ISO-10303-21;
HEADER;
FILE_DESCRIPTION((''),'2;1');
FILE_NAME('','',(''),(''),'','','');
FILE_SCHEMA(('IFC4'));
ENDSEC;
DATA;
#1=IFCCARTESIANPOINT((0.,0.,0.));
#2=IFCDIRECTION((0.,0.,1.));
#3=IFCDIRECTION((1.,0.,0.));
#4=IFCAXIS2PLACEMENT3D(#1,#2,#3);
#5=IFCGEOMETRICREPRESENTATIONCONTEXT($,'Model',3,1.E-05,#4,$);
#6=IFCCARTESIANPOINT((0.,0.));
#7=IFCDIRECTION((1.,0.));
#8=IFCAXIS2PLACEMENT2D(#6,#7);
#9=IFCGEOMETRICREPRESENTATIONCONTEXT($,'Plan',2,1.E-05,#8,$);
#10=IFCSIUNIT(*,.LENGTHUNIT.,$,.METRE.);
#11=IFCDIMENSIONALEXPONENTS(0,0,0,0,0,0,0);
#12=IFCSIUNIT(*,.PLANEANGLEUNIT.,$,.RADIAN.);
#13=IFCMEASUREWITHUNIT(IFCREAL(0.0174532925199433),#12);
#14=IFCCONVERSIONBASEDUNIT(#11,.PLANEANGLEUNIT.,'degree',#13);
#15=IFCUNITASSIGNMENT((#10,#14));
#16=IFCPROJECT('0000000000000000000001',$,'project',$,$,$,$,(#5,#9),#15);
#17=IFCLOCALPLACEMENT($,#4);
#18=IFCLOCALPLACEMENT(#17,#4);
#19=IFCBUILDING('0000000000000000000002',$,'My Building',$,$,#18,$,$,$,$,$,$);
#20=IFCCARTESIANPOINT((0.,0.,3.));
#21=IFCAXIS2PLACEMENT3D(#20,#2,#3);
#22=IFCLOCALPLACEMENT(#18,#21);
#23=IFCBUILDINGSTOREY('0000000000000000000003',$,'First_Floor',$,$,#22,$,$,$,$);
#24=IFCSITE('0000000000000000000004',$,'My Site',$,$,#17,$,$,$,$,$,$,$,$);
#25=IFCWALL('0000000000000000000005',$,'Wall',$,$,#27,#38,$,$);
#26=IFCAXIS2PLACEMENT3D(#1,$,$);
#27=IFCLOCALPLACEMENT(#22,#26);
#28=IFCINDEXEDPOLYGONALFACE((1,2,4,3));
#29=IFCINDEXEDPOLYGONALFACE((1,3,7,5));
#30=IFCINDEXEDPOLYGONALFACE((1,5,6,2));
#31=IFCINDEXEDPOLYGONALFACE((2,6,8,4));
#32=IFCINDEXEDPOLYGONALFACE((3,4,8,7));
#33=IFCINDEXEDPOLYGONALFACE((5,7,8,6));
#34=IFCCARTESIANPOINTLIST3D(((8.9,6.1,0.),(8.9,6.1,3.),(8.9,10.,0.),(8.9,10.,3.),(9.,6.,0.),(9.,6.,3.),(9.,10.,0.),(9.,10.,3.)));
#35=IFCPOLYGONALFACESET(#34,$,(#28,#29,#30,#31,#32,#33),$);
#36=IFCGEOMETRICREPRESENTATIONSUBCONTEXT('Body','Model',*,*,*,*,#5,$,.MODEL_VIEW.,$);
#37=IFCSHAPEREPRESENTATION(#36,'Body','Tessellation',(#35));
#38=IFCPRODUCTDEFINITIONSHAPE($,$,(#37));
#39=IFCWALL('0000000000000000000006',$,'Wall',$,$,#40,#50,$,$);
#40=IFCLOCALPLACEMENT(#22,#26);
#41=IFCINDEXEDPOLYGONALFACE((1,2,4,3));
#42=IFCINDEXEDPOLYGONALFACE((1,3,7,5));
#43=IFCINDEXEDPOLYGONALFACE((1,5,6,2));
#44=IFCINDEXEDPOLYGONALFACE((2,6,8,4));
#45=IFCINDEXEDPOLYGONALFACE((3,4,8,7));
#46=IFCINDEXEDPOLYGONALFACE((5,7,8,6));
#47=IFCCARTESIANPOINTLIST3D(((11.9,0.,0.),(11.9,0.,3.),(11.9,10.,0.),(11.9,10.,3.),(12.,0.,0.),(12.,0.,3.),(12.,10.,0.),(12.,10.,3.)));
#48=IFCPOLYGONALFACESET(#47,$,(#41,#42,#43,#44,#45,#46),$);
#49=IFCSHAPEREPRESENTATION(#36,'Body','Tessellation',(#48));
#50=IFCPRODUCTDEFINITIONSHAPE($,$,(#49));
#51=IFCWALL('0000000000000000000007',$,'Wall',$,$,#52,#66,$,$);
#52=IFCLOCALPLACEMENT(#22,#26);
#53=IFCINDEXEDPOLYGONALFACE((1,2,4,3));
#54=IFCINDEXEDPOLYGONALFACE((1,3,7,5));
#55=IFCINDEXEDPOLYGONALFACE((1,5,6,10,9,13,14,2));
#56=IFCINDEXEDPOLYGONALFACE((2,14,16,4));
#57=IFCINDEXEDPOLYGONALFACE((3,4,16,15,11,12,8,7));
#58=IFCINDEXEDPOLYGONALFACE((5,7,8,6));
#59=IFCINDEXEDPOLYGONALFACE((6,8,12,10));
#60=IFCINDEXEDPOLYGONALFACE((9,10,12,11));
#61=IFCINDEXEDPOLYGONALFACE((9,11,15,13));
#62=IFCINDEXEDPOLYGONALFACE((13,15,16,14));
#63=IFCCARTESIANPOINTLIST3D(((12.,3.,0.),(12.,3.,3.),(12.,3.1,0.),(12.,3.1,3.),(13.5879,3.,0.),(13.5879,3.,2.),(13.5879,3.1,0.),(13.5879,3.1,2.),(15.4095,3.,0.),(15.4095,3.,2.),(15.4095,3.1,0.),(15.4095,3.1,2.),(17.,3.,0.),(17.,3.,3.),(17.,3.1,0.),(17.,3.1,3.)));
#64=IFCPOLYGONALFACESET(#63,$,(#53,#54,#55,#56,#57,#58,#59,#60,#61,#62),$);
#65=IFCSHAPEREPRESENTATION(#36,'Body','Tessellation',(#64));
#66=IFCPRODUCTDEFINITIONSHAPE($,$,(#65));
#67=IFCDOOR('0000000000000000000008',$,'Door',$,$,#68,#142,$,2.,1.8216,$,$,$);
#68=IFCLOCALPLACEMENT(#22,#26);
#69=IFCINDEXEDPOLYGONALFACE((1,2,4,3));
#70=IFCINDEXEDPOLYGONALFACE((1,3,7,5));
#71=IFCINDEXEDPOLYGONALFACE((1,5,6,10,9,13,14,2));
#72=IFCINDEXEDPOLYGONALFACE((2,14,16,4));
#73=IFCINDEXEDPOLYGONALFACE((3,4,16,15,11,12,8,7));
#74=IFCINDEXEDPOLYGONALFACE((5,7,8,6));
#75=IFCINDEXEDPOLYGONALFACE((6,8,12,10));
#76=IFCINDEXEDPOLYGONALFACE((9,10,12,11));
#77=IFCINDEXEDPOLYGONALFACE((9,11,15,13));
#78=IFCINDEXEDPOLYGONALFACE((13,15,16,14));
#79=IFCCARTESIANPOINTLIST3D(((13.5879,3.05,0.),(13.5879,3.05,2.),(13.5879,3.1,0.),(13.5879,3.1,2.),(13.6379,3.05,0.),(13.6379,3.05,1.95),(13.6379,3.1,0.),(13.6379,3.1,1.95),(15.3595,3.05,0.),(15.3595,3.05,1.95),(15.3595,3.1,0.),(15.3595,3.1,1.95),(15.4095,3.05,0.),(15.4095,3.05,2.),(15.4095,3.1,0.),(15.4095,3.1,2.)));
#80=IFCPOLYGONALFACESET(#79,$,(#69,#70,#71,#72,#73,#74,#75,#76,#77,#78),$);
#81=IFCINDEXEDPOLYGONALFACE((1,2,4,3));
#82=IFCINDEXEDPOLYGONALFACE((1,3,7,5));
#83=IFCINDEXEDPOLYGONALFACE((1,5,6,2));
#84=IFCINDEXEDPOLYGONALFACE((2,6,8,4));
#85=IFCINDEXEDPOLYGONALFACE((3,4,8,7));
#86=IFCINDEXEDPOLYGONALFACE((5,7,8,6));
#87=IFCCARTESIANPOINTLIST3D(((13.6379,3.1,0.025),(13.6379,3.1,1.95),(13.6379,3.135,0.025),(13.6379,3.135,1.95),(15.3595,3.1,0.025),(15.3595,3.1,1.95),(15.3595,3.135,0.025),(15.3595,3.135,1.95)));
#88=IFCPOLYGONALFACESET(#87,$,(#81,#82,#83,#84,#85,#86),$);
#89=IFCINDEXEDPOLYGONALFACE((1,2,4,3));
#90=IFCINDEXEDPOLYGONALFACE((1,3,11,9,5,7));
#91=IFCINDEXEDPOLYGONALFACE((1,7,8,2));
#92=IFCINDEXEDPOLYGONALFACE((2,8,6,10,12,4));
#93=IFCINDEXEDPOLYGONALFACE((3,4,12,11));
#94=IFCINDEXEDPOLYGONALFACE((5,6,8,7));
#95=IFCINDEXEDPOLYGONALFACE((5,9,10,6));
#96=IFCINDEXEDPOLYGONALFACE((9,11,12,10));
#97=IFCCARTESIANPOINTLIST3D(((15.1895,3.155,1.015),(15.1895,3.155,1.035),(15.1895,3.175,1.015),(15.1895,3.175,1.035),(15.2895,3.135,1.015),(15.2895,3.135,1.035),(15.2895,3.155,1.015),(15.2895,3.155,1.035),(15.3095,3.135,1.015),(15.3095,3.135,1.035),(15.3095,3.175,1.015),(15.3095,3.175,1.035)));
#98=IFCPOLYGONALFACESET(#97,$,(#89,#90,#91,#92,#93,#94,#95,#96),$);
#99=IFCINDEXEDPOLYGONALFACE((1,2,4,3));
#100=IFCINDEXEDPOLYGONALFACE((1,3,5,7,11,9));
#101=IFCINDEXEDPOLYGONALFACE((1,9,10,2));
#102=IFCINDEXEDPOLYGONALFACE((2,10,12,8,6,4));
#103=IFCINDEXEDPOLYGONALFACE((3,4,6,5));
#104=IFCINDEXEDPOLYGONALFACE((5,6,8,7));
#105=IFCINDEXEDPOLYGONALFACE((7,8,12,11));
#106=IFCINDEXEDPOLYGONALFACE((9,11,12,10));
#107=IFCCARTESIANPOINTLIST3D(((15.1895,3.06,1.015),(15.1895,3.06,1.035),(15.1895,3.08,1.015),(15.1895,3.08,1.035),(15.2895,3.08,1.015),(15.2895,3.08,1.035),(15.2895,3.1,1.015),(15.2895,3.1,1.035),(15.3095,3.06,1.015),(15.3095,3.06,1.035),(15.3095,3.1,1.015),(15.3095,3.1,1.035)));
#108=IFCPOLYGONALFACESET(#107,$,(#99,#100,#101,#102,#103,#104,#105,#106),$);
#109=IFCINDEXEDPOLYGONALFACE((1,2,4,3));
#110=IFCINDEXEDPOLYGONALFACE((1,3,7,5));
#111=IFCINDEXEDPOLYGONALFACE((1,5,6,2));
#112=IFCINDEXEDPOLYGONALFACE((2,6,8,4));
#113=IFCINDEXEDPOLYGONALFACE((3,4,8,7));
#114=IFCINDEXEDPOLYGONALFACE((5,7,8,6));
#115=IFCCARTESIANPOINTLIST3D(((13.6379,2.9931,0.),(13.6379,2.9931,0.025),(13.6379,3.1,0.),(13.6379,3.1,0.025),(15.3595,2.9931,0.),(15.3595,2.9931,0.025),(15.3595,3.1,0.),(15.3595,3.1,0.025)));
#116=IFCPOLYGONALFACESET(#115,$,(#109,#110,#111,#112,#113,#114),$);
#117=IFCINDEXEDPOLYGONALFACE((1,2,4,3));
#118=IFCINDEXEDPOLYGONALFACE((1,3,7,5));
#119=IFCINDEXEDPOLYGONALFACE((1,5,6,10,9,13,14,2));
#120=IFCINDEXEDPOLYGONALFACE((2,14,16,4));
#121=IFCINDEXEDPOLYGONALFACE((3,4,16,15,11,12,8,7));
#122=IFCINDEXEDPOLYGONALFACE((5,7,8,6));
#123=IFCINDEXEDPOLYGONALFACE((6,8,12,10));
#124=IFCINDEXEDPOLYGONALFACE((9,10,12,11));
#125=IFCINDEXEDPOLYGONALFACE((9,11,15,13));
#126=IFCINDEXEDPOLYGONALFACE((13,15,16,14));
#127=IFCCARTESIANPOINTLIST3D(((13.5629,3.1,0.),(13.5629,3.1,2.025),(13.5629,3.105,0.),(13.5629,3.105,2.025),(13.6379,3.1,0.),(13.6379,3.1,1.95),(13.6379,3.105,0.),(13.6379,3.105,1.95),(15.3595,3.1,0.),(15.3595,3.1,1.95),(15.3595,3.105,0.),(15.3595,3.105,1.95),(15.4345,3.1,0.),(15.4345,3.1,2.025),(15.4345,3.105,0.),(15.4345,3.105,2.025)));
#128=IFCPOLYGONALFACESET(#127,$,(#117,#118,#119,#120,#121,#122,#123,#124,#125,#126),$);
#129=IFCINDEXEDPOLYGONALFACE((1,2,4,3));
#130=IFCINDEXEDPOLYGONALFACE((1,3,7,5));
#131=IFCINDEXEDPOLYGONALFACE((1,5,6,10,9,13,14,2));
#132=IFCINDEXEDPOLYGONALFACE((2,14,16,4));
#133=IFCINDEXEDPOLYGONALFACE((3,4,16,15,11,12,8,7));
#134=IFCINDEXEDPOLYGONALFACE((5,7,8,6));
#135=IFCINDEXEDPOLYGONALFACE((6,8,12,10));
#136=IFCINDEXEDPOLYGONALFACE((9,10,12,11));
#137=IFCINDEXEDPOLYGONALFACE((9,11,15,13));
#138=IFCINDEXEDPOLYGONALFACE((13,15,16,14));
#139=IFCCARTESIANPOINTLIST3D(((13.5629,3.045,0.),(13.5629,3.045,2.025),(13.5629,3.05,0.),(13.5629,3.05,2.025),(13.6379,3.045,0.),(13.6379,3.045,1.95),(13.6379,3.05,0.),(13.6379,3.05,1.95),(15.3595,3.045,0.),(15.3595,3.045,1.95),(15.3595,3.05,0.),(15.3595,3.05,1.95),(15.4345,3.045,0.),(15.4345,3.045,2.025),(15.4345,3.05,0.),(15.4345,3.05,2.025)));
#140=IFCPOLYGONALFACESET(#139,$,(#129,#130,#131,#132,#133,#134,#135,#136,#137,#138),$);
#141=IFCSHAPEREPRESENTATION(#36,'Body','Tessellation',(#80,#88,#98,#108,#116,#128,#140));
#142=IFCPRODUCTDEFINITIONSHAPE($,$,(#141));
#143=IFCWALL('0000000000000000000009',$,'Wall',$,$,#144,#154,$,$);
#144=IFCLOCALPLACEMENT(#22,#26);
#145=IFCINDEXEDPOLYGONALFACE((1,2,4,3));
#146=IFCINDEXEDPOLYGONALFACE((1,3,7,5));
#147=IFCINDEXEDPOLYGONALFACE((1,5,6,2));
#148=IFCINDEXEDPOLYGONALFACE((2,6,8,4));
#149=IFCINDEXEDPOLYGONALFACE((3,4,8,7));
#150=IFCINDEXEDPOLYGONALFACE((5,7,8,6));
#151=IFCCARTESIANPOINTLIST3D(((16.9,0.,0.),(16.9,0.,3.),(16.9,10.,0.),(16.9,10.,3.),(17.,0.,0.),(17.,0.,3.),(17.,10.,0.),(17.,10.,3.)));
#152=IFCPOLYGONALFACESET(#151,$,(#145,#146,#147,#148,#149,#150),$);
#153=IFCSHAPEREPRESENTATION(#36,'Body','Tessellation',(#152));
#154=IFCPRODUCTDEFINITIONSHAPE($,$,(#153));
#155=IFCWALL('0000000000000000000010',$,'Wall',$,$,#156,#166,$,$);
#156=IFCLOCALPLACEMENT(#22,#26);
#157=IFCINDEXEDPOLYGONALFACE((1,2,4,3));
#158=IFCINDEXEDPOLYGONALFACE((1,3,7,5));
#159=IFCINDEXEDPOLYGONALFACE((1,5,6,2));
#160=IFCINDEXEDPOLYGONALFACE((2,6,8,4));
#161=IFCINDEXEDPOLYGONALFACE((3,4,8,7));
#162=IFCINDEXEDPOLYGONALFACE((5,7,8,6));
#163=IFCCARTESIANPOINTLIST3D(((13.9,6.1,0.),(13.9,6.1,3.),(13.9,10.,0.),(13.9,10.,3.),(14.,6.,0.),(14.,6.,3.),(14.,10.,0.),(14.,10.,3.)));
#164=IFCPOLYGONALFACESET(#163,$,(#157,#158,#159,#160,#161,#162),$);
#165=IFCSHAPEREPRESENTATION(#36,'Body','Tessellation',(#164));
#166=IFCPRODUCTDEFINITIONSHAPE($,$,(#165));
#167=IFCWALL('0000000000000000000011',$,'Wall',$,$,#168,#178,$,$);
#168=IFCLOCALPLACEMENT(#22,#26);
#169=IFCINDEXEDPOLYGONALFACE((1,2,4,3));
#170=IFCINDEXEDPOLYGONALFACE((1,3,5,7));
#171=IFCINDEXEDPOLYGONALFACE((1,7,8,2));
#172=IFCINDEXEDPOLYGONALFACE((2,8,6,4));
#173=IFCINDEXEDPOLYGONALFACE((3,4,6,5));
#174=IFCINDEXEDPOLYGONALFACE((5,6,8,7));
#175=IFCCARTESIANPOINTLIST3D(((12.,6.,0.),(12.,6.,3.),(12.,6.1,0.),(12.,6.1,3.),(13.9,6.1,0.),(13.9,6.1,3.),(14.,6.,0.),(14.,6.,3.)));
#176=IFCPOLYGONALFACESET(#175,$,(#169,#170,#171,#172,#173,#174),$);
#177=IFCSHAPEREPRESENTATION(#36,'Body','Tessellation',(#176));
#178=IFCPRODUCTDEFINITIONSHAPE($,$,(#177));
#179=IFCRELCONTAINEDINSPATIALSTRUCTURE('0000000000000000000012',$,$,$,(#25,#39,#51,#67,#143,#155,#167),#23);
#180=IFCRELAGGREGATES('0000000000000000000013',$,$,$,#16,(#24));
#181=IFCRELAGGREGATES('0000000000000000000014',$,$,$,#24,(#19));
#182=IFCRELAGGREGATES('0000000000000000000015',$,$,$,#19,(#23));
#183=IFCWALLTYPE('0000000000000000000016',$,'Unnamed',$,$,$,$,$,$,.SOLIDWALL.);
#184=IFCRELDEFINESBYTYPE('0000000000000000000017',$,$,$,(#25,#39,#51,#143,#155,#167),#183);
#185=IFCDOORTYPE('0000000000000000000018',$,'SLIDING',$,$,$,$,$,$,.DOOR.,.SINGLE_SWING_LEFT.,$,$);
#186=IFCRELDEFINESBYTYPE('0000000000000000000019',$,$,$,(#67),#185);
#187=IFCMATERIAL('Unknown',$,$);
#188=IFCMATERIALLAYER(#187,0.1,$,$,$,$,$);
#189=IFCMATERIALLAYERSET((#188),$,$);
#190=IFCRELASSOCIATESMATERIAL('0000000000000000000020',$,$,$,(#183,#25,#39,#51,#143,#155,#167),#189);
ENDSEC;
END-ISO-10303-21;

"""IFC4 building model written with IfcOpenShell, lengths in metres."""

from ifc_helpers import new_model, entity, si_unit, converted_unit, frame, origin_with_axes, origin_2d_with_axis, place, context, subcontext, project, spatial, line, indexed_curve, outline, extrude, shape, source, transform, mapped, material, layer, layer_set, layer_usage, type_object, type_shapes, element, fill, save


model = new_model("IFC4")

# Units and contexts
model_context = context("Model", 3, precision=1e-05, world=origin_with_axes())
plan_context = context("Plan", 2, precision=1e-05, world=origin_2d_with_axis())
body_context_1 = subcontext(model_context, "Body", "Model", "MODEL_VIEW")
body_context_2 = subcontext(plan_context, "Body", "Plan", "PLAN_VIEW")
ifc_project = project(units=[si_unit("LENGTHUNIT", "METRE"), converted_unit("PLANEANGLEUNIT", "degree", entity("IfcReal", 0.0174532925199433), si_unit("PLANEANGLEUNIT", "RADIAN"), dimensions=[0, 0, 0, 0, 0, 0, 0])], contexts=[model_context, plan_context])

# Site, building, storey
site_placement = place(None, origin_with_axes())
site = spatial("IfcSite", under=ifc_project, at=site_placement, Name="My Site")
building_placement = place(site_placement, origin_with_axes())
building = spatial("IfcBuilding", under=site, at=building_placement, Name="My Building")
storey_placement = place(building_placement, frame((0.0, 0.0, 3.0), z_axis=(0.0, 0.0, 1.0), x_axis=(1.0, 0.0, 0.0)))
storey = spatial("IfcBuildingStorey", under=building, at=storey_placement, Name="First_Floor")

# Shared definitions
ifc_material = material(Name="Unknown")
ifc_layer = layer(ifc_material, 0.1)
ifc_layer_set = layer_set([ifc_layer])
wall_type = type_object("IfcWallType", Name="Unnamed", PredefinedType="SOLIDWALL", material=ifc_layer_set)

# Shared definitions
shared_shape_1 = source(origin_with_axes(), body_context_1, "Body", "SweptSolid", [
    extrude(outline(indexed_curve([(0.0, 0.0), (1.8216, 0.0), (1.8216, 2.0), (0.0, 2.0)], segments=[line(1, 2, 3, 4, 1)])), frame((0.0, -0.6, 0.0), z_axis=(0.0, -1.0, 0.0), x_axis=(1.0, 0.0, 0.0)), (0.0, 0.0, -1.0), 1.2),
])
door_type_1 = type_object("IfcDoorType", Name="SLIDING", OperationType="SINGLE_SWING_LEFT", PredefinedType="DOOR")
shared_shape_2 = source(origin_with_axes(), body_context_1, "Body", "SweptSolid", [
    extrude(outline(indexed_curve([(0.0, 0.0), (0.0, 2.0), (1.8216, 2.0), (1.8216, 0.0), (1.7716, 0.0), (1.7716, 1.95), (0.05, 1.95), (0.05, 0.0)], segments=[line(1, 2, 3, 4, 5, 6, 7, 8, 1)])), frame((0.0, 0.0, 0.0), z_axis=(0.0, -1.0, 0.0), x_axis=(1.0, 0.0, 0.0)), (0.0, 0.0, -1.0), 0.05),
    extrude(outline(indexed_curve([(0.0, 0.0), (1.7216, 0.0), (1.7216, 0.035), (0.0, 0.035)], segments=[line(1, 2, 3, 4, 1)])), frame((0.05, -0.035, 0.025), z_axis=(0.0, 0.0, 1.0), x_axis=(1.0, 0.0, 0.0)), (0.0, 0.0, 1.0), 1.925),
    extrude(outline(indexed_curve([(0.0, 0.0), (0.0, -0.04), (0.12, -0.04), (0.12, -0.02), (0.02, -0.02), (0.02, 0.0)], segments=[line(1, 2, 3, 4, 5, 6, 1)])), frame((0.1, -0.035, 1.015), z_axis=(0.0, 0.0, 1.0), x_axis=(1.0, 0.0, 0.0)), (0.0, 0.0, 1.0), 0.02),
    extrude(outline(indexed_curve([(0.0, 0.0), (0.0, 0.04), (0.12, 0.04), (0.12, 0.02), (0.02, 0.02), (0.02, 0.0)], segments=[line(1, 2, 3, 4, 5, 6, 1)])), frame((0.1, 0.0, 1.015), z_axis=(0.0, 0.0, 1.0), x_axis=(1.0, 0.0, 0.0)), (0.0, 0.0, 1.0), 0.02),
    extrude(outline(indexed_curve([(0.0, 0.0), (1.7216, 0.0), (1.7216, 0.1069), (0.0, 0.1069)], segments=[line(1, 2, 3, 4, 1)])), frame((0.05, 0.0, 0.0), z_axis=(0.0, 0.0, 1.0), x_axis=(1.0, 0.0, 0.0)), (0.0, 0.0, 1.0), 0.025),
    extrude(outline(indexed_curve([(0.0, 0.0), (0.0, 2.025), (1.8716, 2.025), (1.8716, 0.0), (1.7966, 0.0), (1.7966, 1.95), (0.075, 1.95), (0.075, 0.0)], segments=[line(1, 2, 3, 4, 5, 6, 7, 8, 1)])), frame((-0.025, -0.005, 0.0), z_axis=(0.0, -1.0, 0.0), x_axis=(1.0, 0.0, 0.0)), (0.0, 0.0, -1.0), 0.005),
    extrude(outline(indexed_curve([(0.0, 0.0), (0.0, 2.025), (1.8716, 2.025), (1.8716, 0.0), (1.7966, 0.0), (1.7966, 1.95), (0.075, 1.95), (0.075, 0.0)], segments=[line(1, 2, 3, 4, 5, 6, 7, 8, 1)])), frame((-0.025, 0.05, 0.0), z_axis=(0.0, -1.0, 0.0), x_axis=(1.0, 0.0, 0.0)), (0.0, 0.0, -1.0), 0.005),
])
shared_shape_3 = source(origin_with_axes(), body_context_2, "Body", "Curve2D", [
    entity("IfcIndexedPolyCurve", entity("IfcCartesianPointList2D", [[0.0, 0.0], [0.05, 0.0], [0.05, 0.05], [0.0, 0.05]]), [entity("IfcLineIndex", [1, 2, 3, 4, 1])]),
    entity("IfcIndexedPolyCurve", entity("IfcCartesianPointList2D", [[1.8216, 0.0], [1.7716, 0.0], [1.7716, 0.05], [1.8216, 0.05]]), [entity("IfcLineIndex", [1, 2, 3, 4, 1])]),
    entity("IfcIndexedPolyCurve", entity("IfcCartesianPointList2D", [[2.6325, -0.035], [0.9108, -0.035], [0.9108, 0.0], [2.6325, 0.0]]), [entity("IfcLineIndex", [1, 2, 3, 4, 1])]),
])
type_shapes(door_type_1, [shared_shape_2, shared_shape_3])

# Walls
ifc_layer_usage_1 = layer_usage(ifc_layer_set, "AXIS2", "POSITIVE", 0.0)
wall_1_placement = place(storey_placement, frame((9.0, 6.0, 0.0), z_axis=(0.0, 0.0, 1.0), x_axis=(0.0, 1.0, 0.0)))
element("IfcWall", 1, at=wall_1_placement, inside=storey, type_object=wall_type, material=ifc_layer_usage_1, Name="Wall", context=body_context_1, shape_type="SweptSolid", body=[
    extrude(outline(indexed_curve([(0.0, 0.0), (0.1, 0.1), (4.0, 0.1), (4.0, 0.0)], segments=[line(1, 2, 3, 4, 1)])), origin_with_axes(), (0.0, 0.0, 1.0), 3.0),
])
ifc_layer_usage_2 = layer_usage(ifc_layer_set, "AXIS2", "POSITIVE", 0.0)
wall_2_placement = place(storey_placement, frame((11.9, 10.0, 0.0), z_axis=(0.0, 0.0, 1.0), x_axis=(0.0, -1.0, 0.0)))
element("IfcWall", 2, at=wall_2_placement, inside=storey, type_object=wall_type, material=ifc_layer_usage_2, Name="Wall", context=body_context_1, shape_type="SweptSolid", body=[
    extrude(outline(indexed_curve([(0.0, 0.0), (0.0, 0.1), (10.0, 0.1), (10.0, 0.0)], segments=[line(1, 2, 3, 4, 1)])), origin_with_axes(), (0.0, 0.0, 1.0), 3.0),
])

# Wall, opening, door
ifc_layer_usage_3 = layer_usage(ifc_layer_set, "AXIS2", "POSITIVE", 0.0)
wall_3_placement = place(storey_placement, frame((12.0, 3.0, 0.0), z_axis=(0.0, 0.0, 1.0), x_axis=(1.0, 0.0, 0.0)))
wall_3 = element("IfcWall", 3, at=wall_3_placement, inside=storey, type_object=wall_type, material=ifc_layer_usage_3, Name="Wall", context=body_context_1, shape_type="SweptSolid", body=[
    extrude(outline(indexed_curve([(0.0, 0.0), (0.0, 0.1), (5.0, 0.1), (5.0, 0.0)], segments=[line(1, 2, 3, 4, 1)])), origin_with_axes(), (0.0, 0.0, 1.0), 3.0),
])
opening_1_placement = place(wall_3_placement, frame((3.4095, 0.1, 0.0), z_axis=(0.0, 0.0, 1.0), x_axis=(-1.0, 0.0, 0.0)))
opening_1 = element("IfcOpeningElement", 4, at=opening_1_placement, cuts=wall_3, PredefinedType="OPENING", context=body_context_1, shape_type="MappedRepresentation", body=[
    mapped(shared_shape_1, transform((0.0, 0.0, 0.0), x_axis=(1.0, 0.0, 0.0), y_axis=(0.0, 1.0, 0.0), z_axis=(0.0, 0.0, 1.0), scale=1.0)),
])
door_1_placement = place(opening_1_placement, frame((0.0, 0.0, 0.0), z_axis=(0.0, 0.0, 1.0), x_axis=(1.0, 0.0, 0.0)))
door_1 = element("IfcDoor", 5, at=door_1_placement, inside=storey, type_object=door_type_1, Name="Door", OverallHeight=2.0, OverallWidth=1.8216, shapes=[
    shape(body_context_1, "Body", "MappedRepresentation", [mapped(shared_shape_2, transform((0.0, 0.0, 0.0), x_axis=(1.0, 0.0, 0.0), y_axis=(0.0, 1.0, 0.0), z_axis=(0.0, 0.0, 1.0), scale=1.0))]),
    shape(body_context_2, "Body", "MappedRepresentation", [mapped(shared_shape_3, transform((0.0, 0.0, 0.0), x_axis=(1.0, 0.0, 0.0), y_axis=(0.0, 1.0, 0.0), z_axis=(0.0, 0.0, 1.0), scale=1.0))]),
])
fill(opening_1, door_1)

# Walls
ifc_layer_usage_4 = layer_usage(ifc_layer_set, "AXIS2", "POSITIVE", 0.0)
wall_4_placement = place(storey_placement, frame((16.9, 10.0, 0.0), z_axis=(0.0, 0.0, 1.0), x_axis=(0.0, -1.0, 0.0)))
element("IfcWall", 6, at=wall_4_placement, inside=storey, type_object=wall_type, material=ifc_layer_usage_4, Name="Wall", context=body_context_1, shape_type="SweptSolid", body=[
    extrude(outline(indexed_curve([(0.0, 0.0), (0.0, 0.1), (10.0, 0.1), (10.0, 0.0)], segments=[line(1, 2, 3, 4, 1)])), origin_with_axes(), (0.0, 0.0, 1.0), 3.0),
])
ifc_layer_usage_5 = layer_usage(ifc_layer_set, "AXIS2", "POSITIVE", 0.0)
wall_5_placement = place(storey_placement, frame((14.0, 6.0, 0.0), z_axis=(0.0, 0.0, 1.0), x_axis=(0.0, 1.0, 0.0)))
element("IfcWall", 7, at=wall_5_placement, inside=storey, type_object=wall_type, material=ifc_layer_usage_5, Name="Wall", context=body_context_1, shape_type="SweptSolid", body=[
    extrude(outline(indexed_curve([(0.0, 0.0), (0.1, 0.1), (4.0, 0.1), (4.0, 0.0)], segments=[line(1, 2, 3, 4, 1)])), origin_with_axes(), (0.0, 0.0, 1.0), 3.0),
])
ifc_layer_usage_6 = layer_usage(ifc_layer_set, "AXIS2", "POSITIVE", 0.0)
wall_6_placement = place(storey_placement, frame((12.0, 6.0, 0.0), z_axis=(0.0, 0.0, 1.0), x_axis=(1.0, 0.0, 0.0)))
element("IfcWall", 8, at=wall_6_placement, inside=storey, type_object=wall_type, material=ifc_layer_usage_6, Name="Wall", context=body_context_1, shape_type="SweptSolid", body=[
    extrude(outline(indexed_curve([(0.0, 0.0), (0.0, 0.1), (1.9, 0.1), (2.0, 0.0)], segments=[line(1, 2, 3, 4, 1)])), origin_with_axes(), (0.0, 0.0, 1.0), 3.0),
])

save(model, "model.ifc")
